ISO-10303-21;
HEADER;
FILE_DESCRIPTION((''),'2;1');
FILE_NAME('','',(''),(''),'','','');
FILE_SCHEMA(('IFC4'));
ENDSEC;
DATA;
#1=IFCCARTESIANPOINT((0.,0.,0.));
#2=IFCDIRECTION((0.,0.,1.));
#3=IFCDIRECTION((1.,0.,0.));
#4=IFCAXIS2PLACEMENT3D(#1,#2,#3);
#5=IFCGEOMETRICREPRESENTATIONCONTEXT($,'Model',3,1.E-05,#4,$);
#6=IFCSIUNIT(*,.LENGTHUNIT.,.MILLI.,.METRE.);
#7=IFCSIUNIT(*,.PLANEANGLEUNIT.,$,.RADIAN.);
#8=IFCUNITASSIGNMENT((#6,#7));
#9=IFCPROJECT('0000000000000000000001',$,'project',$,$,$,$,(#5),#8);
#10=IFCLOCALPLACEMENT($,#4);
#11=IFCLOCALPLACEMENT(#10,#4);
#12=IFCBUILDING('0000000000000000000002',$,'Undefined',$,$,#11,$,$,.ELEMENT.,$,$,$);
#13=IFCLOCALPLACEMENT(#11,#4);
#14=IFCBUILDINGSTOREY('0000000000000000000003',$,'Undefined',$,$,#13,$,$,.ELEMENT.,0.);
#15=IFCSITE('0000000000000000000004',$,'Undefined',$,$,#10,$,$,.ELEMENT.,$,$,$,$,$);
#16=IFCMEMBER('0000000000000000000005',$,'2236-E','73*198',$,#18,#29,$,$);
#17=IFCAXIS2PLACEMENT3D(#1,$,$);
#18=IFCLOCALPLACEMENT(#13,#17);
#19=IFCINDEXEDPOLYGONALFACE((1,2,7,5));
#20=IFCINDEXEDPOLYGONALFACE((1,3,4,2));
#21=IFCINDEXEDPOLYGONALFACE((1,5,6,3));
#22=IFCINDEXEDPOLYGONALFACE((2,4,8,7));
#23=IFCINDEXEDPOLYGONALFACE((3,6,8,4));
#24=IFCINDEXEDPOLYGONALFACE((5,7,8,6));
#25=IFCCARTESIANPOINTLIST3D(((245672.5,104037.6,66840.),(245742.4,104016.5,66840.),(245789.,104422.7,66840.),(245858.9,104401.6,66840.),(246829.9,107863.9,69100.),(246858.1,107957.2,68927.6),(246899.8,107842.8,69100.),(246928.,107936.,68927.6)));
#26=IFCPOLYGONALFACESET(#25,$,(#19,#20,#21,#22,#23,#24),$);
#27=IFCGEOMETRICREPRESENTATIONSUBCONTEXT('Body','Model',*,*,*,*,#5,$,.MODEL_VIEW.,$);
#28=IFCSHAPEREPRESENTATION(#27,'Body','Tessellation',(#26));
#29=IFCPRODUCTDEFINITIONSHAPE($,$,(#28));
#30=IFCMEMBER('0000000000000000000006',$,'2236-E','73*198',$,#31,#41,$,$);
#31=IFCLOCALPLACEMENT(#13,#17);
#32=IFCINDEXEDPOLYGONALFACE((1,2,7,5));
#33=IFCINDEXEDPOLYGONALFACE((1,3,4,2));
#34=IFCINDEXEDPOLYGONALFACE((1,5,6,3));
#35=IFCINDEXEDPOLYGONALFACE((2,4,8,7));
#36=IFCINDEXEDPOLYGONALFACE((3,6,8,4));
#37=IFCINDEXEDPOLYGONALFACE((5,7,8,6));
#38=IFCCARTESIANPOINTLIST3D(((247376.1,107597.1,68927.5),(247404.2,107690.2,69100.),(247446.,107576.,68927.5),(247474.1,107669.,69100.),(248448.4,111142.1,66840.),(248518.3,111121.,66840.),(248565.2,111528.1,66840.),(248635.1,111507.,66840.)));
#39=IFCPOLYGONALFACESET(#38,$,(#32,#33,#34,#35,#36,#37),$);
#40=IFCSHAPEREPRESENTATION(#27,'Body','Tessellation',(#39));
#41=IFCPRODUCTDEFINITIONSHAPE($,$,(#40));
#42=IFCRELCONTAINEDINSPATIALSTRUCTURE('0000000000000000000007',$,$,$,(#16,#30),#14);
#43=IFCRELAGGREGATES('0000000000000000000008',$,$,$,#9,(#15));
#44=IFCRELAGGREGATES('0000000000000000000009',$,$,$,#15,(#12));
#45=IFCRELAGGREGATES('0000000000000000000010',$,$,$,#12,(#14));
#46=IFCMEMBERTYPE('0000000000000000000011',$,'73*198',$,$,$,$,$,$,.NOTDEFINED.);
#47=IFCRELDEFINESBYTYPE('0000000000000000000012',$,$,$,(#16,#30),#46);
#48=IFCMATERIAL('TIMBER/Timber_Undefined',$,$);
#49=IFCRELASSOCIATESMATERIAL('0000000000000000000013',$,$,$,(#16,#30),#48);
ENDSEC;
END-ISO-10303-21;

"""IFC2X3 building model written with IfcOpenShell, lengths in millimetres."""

from ifc_helpers import new_model, si_unit, frame, origin_with_axes, origin_2d_with_axis, place, context, subcontext, project, spatial, rectangle, extrude, clip, halfspace, material, type_object, element, save


model = new_model("IFC2X3")

# Units and contexts
model_context = context("Model", 3, precision=1e-05, world=origin_with_axes())
body_context = subcontext(model_context, "Body", "Model", "MODEL_VIEW")
ifc_project = project(units=[si_unit("LENGTHUNIT", "METRE", prefix="MILLI"), si_unit("PLANEANGLEUNIT", "RADIAN")], contexts=[model_context])

# Site, building, storey
site_placement = place(None, origin_with_axes())
site = spatial("IfcSite", under=ifc_project, at=site_placement, Name="Undefined", CompositionType="ELEMENT")
building_placement = place(site_placement, origin_with_axes())
building = spatial("IfcBuilding", under=site, at=building_placement, Name="Undefined", CompositionType="ELEMENT")
storey_placement = place(building_placement, origin_with_axes())
storey = spatial("IfcBuildingStorey", under=building, at=storey_placement, Name="Undefined", CompositionType="ELEMENT", Elevation=0.0)

# Shared definitions
ifc_material_1 = material(Name="TIMBER/Timber_Undefined")

# Members
member_type = type_object("IfcMemberType", Name="73*198", PredefinedType="NOTDEFINED")
member_1_placement = place(storey_placement, frame((246879.0, 107900.0, 69013.8), z_axis=(-0.957167, 0.289538, 0.0), x_axis=(-0.252047, -0.833226, -0.492144)))
element("IfcMember", 1, at=member_1_placement, inside=storey, type_object=member_type, material=ifc_material_1, Name="2236-E", Description="73*198", context=body_context, shape_type="Clipping", body=[
    clip(extrude(rectangle(XDim=198.0, YDim=73.0, at=origin_2d_with_axis()), frame((9448.4, 0.0, 0.0), z_axis=(-1.0, 0.0, 0.0), x_axis=(0.0, -1.0, 0.0)), (0.0, 0.0, 1.0), 9448.5), halfspace(frame((4746.1, 186.1, 36.5), z_axis=(0.492144, -0.870514, 0.0), x_axis=(0.0, 0.0, -1.0)), False)),
])
member_2_placement = place(storey_placement, frame((247425.1, 107633.1, 69013.8), z_axis=(-0.957167, 0.289538, 0.0), x_axis=(0.252232, 0.833838, -0.491013)))
element("IfcMember", 2, at=member_2_placement, inside=storey, type_object=member_type, material=ifc_material_1, Name="2236-E", Description="73*198", context=body_context, shape_type="Clipping", body=[
    clip(extrude(rectangle(XDim=198.0, YDim=73.0, at=origin_2d_with_axis()), frame((9470.2, 0.0, 0.0), z_axis=(-1.0, 0.0, 0.0), x_axis=(0.0, -1.0, 0.0)), (0.0, 0.0, 1.0), 9470.2), halfspace(frame((4746.2, -179.9, -36.5), z_axis=(0.491013, 0.871152, 0.0), x_axis=(0.0, 0.0, 1.0)), False)),
])

save(model, "model.ifc")
